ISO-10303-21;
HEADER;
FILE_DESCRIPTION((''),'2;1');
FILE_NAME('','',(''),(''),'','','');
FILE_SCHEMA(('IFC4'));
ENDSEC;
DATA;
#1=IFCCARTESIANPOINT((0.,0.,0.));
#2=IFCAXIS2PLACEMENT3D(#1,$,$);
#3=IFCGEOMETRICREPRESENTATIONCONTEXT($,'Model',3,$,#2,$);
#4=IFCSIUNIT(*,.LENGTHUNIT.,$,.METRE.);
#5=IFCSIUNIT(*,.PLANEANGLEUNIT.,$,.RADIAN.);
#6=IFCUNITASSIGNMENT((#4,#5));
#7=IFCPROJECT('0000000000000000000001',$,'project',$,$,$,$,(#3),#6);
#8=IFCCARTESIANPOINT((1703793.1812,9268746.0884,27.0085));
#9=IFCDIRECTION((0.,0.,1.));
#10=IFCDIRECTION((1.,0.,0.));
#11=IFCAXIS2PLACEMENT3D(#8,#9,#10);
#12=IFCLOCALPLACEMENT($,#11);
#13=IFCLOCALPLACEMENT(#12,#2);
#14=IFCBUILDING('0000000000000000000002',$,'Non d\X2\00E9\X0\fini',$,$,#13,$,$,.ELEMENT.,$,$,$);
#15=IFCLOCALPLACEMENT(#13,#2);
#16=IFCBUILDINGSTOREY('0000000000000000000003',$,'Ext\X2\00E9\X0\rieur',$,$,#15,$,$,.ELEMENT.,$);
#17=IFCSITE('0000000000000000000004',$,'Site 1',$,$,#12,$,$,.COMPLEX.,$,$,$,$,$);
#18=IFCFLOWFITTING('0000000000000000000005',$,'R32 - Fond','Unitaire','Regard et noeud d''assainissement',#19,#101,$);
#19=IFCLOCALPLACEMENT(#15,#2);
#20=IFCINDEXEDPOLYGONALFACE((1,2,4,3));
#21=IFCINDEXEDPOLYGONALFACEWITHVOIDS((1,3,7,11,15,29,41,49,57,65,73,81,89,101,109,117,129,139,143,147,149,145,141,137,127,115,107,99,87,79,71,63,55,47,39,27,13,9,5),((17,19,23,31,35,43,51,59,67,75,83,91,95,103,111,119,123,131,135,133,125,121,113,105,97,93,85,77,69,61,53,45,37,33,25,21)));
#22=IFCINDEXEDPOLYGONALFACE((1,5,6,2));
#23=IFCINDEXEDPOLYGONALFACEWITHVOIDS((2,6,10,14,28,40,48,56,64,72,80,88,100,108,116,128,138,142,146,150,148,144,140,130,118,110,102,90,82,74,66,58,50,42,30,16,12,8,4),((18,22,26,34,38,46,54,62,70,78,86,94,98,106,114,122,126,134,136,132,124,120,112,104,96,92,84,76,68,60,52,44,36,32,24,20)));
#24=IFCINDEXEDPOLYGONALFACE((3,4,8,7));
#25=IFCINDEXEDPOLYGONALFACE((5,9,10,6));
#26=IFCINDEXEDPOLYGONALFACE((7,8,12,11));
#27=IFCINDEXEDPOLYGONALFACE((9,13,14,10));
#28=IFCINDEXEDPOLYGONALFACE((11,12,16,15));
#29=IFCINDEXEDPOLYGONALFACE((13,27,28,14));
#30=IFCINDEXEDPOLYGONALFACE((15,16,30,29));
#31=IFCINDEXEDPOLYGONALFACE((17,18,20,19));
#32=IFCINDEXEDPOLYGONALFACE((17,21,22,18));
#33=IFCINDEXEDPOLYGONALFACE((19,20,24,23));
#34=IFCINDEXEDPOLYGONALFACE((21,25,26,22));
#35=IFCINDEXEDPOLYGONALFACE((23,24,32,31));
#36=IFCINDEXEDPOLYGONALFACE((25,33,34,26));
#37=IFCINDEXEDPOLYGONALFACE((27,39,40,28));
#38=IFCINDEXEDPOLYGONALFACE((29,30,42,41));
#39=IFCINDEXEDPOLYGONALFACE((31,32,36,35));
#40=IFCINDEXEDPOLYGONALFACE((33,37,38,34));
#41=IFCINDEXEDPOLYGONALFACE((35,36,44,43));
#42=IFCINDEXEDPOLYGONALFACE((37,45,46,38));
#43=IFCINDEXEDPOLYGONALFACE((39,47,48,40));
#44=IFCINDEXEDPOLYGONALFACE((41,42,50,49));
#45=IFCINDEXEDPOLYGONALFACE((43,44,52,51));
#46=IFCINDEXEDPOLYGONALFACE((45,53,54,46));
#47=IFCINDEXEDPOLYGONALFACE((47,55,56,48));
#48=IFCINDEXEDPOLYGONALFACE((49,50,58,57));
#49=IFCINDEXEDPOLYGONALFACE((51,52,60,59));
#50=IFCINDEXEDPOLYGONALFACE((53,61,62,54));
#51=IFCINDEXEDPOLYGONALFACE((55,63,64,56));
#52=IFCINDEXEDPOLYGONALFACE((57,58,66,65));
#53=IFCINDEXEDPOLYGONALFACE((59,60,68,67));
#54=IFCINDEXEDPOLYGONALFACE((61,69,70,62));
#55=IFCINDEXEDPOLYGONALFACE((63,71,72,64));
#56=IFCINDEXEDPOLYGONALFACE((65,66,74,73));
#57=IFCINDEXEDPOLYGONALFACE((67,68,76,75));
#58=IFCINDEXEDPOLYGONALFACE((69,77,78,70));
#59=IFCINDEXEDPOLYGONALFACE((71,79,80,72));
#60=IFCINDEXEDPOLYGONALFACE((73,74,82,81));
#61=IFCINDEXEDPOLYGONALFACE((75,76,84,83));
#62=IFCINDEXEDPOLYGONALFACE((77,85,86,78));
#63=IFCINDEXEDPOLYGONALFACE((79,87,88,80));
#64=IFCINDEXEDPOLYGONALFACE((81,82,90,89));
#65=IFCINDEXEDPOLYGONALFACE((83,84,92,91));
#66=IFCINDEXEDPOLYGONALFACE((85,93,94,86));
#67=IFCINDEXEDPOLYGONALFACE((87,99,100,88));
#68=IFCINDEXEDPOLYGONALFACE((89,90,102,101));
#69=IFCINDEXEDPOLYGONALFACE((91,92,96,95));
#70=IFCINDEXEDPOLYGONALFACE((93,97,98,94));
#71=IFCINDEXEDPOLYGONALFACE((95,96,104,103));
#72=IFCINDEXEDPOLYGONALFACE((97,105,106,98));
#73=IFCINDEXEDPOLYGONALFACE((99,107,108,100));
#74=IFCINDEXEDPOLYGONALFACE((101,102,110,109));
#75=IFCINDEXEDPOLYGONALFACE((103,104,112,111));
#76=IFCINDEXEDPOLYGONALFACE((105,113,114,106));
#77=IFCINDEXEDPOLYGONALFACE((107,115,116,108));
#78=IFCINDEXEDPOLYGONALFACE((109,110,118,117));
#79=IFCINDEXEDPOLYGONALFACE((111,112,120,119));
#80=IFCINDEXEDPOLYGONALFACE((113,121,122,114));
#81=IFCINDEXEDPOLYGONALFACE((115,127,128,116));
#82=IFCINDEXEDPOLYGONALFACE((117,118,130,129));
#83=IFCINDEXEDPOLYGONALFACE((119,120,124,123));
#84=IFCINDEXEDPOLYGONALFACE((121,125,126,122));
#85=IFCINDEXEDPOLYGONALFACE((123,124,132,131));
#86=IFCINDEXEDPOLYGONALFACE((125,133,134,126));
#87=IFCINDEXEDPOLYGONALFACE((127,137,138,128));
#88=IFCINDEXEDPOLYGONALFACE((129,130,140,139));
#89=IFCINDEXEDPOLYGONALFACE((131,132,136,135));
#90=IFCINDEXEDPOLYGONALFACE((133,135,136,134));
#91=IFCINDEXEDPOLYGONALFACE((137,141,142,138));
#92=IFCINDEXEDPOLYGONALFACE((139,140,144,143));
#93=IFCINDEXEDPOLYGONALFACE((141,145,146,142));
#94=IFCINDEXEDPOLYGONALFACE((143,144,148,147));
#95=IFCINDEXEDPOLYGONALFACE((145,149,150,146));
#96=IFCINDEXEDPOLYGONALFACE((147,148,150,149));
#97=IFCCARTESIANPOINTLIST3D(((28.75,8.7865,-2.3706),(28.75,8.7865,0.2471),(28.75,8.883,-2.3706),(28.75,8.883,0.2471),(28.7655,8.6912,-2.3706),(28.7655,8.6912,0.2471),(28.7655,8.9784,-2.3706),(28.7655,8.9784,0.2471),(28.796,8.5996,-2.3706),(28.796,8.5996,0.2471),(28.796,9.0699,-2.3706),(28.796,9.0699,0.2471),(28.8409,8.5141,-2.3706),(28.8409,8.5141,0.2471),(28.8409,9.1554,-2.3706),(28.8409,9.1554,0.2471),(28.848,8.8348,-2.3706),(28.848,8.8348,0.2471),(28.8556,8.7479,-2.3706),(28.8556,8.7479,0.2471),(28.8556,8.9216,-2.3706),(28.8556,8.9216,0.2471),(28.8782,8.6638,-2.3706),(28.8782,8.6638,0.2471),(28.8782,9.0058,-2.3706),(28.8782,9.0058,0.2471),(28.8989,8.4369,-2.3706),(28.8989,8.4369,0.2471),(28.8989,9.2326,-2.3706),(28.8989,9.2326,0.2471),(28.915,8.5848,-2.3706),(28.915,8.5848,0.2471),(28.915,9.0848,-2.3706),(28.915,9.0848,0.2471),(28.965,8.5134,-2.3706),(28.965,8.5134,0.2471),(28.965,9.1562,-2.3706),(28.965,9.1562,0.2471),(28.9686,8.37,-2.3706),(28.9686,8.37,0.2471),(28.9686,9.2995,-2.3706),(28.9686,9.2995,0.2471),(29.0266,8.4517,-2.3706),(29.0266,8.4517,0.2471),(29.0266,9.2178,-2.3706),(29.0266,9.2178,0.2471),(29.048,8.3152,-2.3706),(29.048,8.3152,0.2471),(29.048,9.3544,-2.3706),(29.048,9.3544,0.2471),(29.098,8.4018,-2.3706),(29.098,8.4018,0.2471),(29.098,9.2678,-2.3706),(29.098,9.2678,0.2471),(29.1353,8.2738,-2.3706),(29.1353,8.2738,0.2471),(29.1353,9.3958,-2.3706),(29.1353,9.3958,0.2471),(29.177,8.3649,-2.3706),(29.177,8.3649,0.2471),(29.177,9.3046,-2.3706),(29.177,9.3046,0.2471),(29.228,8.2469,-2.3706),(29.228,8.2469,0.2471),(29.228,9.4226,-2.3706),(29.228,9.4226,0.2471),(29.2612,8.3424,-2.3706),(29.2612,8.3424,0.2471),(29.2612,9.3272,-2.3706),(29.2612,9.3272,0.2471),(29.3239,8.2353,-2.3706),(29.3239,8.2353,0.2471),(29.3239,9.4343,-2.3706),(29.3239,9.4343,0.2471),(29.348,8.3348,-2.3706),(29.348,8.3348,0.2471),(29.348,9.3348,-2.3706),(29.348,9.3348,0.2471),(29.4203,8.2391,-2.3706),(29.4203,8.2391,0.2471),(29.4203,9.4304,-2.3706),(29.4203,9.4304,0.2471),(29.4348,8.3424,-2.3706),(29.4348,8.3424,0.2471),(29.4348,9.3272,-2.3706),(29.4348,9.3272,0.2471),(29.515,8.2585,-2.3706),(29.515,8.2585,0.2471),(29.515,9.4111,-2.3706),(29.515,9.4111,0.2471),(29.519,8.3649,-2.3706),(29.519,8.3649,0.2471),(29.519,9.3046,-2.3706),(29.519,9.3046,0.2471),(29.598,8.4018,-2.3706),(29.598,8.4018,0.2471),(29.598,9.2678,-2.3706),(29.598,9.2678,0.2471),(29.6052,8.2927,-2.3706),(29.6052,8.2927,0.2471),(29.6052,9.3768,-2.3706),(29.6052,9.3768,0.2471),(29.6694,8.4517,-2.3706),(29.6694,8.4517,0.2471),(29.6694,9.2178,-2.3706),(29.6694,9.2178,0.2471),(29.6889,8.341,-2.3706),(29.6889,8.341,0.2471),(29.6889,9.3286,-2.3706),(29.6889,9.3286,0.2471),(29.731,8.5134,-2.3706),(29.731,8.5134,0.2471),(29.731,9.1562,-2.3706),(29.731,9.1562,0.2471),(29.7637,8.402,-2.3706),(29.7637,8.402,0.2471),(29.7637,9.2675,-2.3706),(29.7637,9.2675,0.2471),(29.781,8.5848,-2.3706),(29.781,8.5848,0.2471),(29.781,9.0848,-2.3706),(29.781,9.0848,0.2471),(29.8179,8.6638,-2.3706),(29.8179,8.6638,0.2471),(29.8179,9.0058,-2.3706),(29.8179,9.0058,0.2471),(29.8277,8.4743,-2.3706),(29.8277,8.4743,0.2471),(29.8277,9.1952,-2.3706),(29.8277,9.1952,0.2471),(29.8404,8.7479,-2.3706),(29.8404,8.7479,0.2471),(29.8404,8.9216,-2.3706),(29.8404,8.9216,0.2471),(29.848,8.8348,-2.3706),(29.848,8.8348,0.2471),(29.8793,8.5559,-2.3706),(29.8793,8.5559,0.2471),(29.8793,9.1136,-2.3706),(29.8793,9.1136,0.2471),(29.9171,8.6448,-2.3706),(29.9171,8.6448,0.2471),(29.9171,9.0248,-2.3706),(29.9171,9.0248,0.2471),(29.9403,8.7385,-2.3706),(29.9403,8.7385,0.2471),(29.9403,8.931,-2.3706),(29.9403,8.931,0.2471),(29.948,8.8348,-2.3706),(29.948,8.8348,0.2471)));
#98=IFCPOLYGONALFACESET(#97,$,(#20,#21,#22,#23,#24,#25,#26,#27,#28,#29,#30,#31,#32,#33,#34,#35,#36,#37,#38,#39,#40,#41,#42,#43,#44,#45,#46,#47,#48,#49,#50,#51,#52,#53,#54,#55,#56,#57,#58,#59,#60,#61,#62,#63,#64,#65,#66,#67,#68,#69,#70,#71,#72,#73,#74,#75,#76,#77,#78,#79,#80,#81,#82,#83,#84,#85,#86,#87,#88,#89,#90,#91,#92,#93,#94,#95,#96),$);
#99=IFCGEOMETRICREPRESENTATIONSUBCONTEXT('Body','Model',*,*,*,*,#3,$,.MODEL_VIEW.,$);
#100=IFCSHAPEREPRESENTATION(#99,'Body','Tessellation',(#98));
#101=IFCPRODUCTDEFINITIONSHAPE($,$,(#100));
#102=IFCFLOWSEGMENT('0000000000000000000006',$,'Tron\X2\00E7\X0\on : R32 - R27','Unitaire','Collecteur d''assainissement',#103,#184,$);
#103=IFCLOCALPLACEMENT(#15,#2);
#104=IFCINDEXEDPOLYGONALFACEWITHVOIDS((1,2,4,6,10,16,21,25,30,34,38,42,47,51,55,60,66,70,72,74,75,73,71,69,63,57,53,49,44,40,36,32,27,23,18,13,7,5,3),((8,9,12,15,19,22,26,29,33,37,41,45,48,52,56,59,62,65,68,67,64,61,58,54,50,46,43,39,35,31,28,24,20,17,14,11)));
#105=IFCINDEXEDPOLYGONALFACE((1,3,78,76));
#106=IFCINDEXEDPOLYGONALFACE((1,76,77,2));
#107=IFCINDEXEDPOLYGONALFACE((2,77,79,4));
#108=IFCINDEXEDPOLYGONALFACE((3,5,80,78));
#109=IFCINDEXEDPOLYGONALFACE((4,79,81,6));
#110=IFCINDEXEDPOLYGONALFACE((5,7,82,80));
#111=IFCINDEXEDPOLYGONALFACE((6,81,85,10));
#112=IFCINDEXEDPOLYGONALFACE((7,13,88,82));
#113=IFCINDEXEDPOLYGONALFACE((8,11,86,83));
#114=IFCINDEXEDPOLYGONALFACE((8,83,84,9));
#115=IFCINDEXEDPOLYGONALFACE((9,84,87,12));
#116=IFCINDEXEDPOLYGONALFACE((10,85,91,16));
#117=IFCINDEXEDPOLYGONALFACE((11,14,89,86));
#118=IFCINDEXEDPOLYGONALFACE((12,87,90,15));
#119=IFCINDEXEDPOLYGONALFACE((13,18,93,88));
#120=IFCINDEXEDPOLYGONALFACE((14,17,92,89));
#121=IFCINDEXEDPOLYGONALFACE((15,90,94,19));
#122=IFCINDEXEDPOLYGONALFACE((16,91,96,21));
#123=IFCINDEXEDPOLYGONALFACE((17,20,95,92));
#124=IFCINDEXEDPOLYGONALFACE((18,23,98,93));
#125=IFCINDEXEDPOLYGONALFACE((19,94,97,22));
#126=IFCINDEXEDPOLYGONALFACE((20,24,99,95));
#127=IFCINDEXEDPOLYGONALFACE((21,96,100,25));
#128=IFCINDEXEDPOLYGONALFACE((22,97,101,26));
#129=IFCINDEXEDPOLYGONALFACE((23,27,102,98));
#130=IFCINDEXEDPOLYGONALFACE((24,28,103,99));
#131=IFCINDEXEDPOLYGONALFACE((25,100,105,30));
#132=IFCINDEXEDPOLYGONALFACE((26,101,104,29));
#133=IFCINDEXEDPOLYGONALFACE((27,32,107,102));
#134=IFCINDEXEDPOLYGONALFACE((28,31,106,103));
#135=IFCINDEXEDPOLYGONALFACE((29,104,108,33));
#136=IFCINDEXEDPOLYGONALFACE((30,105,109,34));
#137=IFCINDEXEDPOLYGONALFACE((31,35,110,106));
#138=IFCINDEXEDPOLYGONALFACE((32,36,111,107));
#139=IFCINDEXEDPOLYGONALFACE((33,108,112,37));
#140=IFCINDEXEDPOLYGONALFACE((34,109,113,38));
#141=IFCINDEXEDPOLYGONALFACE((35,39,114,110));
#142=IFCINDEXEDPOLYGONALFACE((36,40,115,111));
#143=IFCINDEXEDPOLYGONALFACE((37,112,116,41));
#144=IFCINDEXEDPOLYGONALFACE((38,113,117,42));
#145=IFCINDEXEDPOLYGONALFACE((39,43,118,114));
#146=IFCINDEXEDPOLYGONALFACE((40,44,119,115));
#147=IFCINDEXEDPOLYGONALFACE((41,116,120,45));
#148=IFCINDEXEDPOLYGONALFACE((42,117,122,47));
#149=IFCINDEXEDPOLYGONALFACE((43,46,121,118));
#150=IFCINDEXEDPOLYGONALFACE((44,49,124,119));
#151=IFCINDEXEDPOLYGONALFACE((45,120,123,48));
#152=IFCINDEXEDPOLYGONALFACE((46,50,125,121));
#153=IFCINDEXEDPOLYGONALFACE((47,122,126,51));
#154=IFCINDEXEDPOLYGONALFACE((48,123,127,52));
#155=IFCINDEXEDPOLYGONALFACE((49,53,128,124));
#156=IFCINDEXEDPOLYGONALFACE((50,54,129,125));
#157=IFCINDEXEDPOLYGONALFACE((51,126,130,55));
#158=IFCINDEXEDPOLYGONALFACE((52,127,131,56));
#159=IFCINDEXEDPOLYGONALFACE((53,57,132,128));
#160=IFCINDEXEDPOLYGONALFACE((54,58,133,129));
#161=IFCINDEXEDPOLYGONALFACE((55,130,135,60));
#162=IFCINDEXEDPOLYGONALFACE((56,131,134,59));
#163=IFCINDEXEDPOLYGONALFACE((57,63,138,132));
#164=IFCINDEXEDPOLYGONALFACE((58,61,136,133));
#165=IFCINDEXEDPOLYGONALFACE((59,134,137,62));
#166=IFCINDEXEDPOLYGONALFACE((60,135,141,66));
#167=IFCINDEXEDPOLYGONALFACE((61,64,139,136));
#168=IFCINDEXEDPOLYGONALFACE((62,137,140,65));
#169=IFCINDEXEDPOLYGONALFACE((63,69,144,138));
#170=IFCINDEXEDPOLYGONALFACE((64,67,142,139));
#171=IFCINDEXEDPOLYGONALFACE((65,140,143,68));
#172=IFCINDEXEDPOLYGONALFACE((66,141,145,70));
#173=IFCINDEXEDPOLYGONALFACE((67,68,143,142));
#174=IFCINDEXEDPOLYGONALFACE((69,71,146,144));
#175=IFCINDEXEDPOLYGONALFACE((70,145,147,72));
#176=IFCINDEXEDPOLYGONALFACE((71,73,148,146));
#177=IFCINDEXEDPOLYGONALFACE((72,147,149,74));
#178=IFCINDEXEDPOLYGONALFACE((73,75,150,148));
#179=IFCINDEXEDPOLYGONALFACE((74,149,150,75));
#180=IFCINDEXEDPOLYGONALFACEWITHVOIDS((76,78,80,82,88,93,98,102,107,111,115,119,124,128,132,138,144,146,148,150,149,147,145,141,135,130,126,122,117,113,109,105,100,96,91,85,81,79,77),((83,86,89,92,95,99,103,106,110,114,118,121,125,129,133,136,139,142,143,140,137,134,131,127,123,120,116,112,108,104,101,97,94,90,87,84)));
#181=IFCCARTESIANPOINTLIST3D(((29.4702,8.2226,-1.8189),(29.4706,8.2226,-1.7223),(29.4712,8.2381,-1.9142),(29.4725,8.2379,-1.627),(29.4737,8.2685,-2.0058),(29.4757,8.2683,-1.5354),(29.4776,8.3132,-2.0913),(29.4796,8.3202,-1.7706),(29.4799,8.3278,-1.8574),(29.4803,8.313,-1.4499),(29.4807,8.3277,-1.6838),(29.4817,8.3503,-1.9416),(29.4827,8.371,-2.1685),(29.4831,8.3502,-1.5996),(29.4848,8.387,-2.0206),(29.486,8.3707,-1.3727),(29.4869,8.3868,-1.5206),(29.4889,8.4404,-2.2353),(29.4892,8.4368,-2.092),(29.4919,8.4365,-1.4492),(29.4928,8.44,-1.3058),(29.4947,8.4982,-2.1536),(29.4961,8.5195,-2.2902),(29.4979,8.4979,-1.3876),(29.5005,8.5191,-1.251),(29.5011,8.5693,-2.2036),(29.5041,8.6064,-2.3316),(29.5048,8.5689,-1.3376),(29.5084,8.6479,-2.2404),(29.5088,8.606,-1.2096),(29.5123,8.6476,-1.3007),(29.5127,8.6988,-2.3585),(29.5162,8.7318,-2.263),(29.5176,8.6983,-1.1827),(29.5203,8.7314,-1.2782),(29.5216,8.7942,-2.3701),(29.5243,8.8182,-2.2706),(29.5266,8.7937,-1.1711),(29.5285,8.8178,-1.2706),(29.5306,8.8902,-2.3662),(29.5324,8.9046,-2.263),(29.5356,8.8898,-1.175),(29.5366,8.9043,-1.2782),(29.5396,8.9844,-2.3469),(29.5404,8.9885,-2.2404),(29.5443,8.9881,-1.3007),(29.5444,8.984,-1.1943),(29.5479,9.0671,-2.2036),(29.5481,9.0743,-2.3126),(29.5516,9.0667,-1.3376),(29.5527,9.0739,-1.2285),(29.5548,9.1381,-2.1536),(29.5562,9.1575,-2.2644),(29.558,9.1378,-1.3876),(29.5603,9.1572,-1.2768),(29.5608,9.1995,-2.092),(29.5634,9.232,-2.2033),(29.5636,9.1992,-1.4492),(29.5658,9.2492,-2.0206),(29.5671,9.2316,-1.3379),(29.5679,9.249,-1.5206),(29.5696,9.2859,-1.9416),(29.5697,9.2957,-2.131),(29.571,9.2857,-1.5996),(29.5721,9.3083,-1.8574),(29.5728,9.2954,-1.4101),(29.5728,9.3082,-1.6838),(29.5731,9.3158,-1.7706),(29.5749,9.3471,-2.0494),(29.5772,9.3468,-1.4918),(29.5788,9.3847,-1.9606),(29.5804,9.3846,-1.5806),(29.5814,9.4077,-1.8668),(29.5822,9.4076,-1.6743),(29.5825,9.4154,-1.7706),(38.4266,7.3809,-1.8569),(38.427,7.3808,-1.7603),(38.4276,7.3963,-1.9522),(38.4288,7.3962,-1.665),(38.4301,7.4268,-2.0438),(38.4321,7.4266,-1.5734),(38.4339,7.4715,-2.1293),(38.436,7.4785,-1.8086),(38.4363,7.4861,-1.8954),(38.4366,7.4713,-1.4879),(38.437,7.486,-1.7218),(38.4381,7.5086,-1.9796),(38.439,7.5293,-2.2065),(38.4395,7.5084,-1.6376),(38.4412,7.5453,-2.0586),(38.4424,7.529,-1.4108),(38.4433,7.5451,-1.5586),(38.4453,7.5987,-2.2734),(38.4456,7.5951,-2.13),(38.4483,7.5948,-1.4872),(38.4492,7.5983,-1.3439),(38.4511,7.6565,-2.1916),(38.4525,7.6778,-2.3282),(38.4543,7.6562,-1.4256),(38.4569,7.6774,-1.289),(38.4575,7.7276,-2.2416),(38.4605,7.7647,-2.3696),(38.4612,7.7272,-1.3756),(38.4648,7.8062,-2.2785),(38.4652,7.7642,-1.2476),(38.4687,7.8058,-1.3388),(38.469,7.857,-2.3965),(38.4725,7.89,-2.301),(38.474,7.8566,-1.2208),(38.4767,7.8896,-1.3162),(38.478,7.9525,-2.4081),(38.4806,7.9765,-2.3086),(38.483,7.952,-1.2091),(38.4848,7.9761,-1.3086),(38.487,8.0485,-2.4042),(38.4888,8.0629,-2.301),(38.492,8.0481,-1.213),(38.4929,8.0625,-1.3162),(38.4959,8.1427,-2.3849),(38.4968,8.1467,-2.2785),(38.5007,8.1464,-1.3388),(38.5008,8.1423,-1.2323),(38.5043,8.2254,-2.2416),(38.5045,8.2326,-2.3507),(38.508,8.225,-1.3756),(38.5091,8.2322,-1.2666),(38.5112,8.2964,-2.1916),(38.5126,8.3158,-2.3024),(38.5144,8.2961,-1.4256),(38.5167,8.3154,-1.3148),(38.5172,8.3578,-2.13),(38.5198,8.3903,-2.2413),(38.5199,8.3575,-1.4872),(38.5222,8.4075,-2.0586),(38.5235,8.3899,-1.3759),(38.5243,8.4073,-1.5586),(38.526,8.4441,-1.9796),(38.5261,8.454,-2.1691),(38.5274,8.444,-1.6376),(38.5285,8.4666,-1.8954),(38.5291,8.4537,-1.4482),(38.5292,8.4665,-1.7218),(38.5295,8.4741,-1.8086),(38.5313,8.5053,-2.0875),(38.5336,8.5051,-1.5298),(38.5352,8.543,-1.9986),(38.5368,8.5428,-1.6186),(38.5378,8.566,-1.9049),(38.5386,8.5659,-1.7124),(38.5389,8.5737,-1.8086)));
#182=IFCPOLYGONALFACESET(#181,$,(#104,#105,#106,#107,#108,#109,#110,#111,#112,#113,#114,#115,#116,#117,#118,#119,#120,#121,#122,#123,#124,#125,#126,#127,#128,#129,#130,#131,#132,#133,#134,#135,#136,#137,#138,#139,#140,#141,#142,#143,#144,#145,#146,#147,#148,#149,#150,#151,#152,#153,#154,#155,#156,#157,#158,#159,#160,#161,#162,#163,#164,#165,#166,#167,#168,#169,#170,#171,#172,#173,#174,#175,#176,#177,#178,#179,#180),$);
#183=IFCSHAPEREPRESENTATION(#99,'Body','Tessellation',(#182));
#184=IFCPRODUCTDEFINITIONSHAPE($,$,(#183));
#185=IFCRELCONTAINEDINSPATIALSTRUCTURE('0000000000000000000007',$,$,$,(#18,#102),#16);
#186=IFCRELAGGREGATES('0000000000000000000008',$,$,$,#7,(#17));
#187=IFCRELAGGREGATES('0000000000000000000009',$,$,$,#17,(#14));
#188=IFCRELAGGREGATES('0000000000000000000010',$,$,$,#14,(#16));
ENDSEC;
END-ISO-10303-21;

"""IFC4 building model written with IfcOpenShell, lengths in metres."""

from ifc_helpers import new_model, si_unit, frame, origin, origin_2d, place, context, subcontext, project, spatial, hollow_circle, extrude, element, save


model = new_model("IFC4")

# Units and contexts
model_context = context("Model", 3, world=origin())
body_context = subcontext(model_context, "Body", "Model", "MODEL_VIEW")
ifc_project = project(units=[si_unit("LENGTHUNIT", "METRE"), si_unit("PLANEANGLEUNIT", "RADIAN")], contexts=[model_context])

# Site, building, storey
site_placement = place(None, frame((1703793.1812, 9268746.0884, 27.0085), z_axis=(0.0, 0.0, 1.0), x_axis=(1.0, 0.0, 0.0)))
site = spatial("IfcSite", under=ifc_project, at=site_placement, Name="Site 1", CompositionType="COMPLEX")
building_placement = place(site_placement, origin())
building = spatial("IfcBuilding", under=site, at=building_placement, Name="Non défini", CompositionType="ELEMENT")
storey_placement = place(building_placement, origin())
storey = spatial("IfcBuildingStorey", under=building, at=storey_placement, Name="Extérieur", CompositionType="ELEMENT")

# Flow fitting
flow_fitting_1_placement = place(storey_placement, origin())
element("IfcFlowFitting", 1, at=flow_fitting_1_placement, inside=storey, Name="R32 - Fond", Description="Unitaire", ObjectType="Regard et noeud d'assainissement", context=body_context, shape_type="SweptSolid", body=[
    extrude(hollow_circle(Radius=0.6, WallThickness=0.1, at=origin_2d()), frame((29.348, 8.8348, -2.3706), z_axis=(0.0, 0.0, 1.0), x_axis=(1.0, 0.0, 0.0)), (0.0, 0.0, 1.0), 2.6177),
])

# Flow segment
flow_segment_1_placement = place(storey_placement, origin())
element("IfcFlowSegment", 2, at=flow_segment_1_placement, inside=storey, Name="Tronçon : R32 - R27", Description="Unitaire", ObjectType="Collecteur d'assainissement", context=body_context, shape_type="SweptSolid", body=[
    extrude(hollow_circle(Radius=0.6, WallThickness=0.1, at=origin_2d()), frame((29.5264, 8.818, -1.7706), z_axis=(0.995604, -0.093567, -0.004229), x_axis=(0.093568, 0.995613, 0.0)), (0.0, 0.0, 1.0), 8.9959),
])

save(model, "model.ifc")
